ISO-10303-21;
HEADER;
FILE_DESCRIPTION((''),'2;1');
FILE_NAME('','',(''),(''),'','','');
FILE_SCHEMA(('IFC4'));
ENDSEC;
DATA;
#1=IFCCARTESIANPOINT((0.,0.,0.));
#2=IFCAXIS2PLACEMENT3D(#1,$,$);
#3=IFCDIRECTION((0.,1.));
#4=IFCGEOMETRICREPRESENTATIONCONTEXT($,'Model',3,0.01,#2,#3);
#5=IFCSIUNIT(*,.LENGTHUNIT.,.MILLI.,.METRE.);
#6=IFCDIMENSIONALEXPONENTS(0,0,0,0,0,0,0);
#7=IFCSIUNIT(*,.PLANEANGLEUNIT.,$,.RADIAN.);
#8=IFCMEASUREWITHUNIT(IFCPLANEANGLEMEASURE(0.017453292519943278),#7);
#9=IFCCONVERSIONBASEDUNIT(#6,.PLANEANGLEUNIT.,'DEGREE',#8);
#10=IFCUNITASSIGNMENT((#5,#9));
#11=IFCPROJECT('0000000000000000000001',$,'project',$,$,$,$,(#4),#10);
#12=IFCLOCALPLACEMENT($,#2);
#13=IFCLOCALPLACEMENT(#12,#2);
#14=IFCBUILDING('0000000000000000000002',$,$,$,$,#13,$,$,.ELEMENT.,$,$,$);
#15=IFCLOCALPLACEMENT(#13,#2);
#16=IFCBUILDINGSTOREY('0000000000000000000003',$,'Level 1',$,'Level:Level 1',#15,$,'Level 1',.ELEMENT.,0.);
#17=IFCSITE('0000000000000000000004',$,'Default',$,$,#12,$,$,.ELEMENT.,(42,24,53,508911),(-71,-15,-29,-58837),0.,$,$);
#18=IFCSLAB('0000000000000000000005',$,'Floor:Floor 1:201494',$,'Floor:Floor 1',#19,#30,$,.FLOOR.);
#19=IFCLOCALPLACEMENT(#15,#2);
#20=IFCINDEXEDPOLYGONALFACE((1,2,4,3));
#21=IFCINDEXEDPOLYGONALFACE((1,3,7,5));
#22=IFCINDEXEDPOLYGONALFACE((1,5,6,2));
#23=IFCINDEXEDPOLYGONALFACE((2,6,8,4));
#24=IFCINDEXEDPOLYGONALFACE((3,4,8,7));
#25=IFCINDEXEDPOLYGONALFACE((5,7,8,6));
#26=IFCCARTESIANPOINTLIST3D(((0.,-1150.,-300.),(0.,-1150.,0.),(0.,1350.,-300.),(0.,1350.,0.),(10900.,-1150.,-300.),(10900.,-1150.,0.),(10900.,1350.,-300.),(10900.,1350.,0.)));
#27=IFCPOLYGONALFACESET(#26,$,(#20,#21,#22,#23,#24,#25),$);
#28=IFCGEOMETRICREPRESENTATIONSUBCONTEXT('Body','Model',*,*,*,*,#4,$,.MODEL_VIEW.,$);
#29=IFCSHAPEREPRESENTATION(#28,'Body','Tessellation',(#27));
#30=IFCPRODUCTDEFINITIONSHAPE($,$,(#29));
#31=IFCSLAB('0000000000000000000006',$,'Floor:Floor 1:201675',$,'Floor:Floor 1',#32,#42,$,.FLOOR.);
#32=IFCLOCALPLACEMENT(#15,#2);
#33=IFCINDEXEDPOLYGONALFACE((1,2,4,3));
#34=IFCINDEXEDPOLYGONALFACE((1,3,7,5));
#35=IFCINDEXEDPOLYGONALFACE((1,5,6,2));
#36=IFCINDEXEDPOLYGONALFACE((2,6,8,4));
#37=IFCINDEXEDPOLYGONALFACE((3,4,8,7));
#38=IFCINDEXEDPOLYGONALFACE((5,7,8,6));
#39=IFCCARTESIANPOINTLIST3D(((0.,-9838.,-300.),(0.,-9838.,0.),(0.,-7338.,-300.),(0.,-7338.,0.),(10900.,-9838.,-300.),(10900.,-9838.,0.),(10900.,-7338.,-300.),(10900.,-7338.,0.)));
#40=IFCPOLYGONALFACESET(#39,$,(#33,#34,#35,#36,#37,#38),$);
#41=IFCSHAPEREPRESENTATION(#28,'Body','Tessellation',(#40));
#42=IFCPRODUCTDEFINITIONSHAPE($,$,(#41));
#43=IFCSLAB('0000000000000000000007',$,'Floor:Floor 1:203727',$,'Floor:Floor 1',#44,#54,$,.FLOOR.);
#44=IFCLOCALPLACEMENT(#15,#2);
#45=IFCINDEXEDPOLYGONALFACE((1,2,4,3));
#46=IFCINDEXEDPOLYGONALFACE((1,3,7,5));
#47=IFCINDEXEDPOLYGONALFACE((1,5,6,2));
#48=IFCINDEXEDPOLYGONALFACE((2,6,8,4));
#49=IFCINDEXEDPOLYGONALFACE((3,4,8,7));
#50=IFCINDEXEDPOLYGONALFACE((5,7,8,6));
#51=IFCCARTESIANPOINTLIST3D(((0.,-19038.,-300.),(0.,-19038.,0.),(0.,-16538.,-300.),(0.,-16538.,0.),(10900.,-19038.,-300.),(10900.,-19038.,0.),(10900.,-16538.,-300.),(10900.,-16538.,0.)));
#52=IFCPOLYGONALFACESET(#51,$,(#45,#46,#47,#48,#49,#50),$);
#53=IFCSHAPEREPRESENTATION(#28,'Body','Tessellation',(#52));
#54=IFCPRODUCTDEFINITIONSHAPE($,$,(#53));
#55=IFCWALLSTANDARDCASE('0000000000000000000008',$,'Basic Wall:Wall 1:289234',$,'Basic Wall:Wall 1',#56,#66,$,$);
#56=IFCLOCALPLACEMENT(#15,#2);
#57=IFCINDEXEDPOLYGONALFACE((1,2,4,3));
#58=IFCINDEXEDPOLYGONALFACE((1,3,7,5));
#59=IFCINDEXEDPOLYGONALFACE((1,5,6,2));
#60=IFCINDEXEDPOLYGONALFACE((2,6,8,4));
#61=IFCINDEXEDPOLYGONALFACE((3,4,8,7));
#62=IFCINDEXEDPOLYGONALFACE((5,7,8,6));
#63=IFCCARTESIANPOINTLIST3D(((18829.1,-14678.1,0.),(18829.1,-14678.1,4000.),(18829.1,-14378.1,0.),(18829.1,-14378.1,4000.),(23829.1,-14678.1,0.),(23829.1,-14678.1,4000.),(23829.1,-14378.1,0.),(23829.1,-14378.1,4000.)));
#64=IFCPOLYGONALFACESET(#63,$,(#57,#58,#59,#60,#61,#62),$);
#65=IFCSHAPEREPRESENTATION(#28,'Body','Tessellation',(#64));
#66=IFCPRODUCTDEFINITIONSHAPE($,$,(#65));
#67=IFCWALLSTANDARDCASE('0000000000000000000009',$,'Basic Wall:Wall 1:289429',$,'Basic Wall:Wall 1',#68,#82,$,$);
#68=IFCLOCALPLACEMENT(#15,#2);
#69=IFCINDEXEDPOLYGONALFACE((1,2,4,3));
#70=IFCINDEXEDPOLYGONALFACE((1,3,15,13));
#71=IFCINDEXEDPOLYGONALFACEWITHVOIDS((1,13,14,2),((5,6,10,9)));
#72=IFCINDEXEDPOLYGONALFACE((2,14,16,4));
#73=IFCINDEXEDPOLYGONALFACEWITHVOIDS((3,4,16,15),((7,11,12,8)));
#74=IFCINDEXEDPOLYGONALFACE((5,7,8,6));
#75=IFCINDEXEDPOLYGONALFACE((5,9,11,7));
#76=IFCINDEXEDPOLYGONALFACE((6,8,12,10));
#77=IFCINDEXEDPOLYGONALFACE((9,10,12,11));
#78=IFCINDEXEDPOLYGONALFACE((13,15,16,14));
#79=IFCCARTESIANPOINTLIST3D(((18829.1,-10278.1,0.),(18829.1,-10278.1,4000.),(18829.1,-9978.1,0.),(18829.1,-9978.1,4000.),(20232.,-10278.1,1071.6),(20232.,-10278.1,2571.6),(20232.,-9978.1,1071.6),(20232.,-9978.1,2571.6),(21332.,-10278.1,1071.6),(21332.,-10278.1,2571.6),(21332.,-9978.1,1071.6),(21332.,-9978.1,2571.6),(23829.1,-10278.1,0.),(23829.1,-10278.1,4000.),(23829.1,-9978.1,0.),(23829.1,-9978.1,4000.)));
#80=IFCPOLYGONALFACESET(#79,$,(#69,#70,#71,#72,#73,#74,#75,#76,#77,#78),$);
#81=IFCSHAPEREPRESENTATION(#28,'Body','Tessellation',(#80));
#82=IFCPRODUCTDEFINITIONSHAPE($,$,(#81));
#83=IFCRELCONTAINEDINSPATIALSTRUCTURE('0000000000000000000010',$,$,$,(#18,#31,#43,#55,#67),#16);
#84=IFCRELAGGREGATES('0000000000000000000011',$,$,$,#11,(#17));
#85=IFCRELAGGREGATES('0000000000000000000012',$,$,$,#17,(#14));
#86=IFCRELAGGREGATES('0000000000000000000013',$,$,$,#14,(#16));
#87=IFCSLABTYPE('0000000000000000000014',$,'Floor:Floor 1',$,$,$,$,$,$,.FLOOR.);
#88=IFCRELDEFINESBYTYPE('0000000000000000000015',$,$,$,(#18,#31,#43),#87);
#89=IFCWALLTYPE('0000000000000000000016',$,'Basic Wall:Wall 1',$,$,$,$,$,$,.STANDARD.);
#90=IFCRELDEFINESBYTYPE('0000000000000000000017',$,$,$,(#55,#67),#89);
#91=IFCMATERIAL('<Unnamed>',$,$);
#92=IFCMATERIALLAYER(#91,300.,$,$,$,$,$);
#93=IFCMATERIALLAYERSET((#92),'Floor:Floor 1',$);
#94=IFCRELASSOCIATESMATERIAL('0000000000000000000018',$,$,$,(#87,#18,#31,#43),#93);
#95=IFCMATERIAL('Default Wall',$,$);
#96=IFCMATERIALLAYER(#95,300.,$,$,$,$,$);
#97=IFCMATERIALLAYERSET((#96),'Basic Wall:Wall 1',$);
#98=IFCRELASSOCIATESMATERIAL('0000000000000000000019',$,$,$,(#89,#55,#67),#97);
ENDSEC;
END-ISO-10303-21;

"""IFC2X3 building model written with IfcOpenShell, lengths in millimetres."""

from ifc_helpers import new_model, entity, si_unit, converted_unit, direction, frame, frame_2d, origin, origin_2d_with_axis, place, context, subcontext, project, spatial, rectangle, extrude, material, layer, layer_set, layer_usage, type_object, element, save


model = new_model("IFC2X3")

# Units and contexts
model_context = context("Model", 3, precision=0.01, world=origin(), true_north=direction((0.0, 1.0)))
body_context = subcontext(model_context, "Body", "Model", "MODEL_VIEW")
ifc_project = project(units=[si_unit("LENGTHUNIT", "METRE", prefix="MILLI"), converted_unit("PLANEANGLEUNIT", "DEGREE", entity("IfcPlaneAngleMeasure", 0.017453292519943278), si_unit("PLANEANGLEUNIT", "RADIAN"), dimensions=[0, 0, 0, 0, 0, 0, 0])], contexts=[model_context])

# Site, building, storey
site_placement = place(None, origin())
site = spatial("IfcSite", under=ifc_project, at=site_placement, Name="Default", CompositionType="ELEMENT", RefLatitude=(42, 24, 53, 508911), RefLongitude=(-71, -15, -29, -58837), RefElevation=0.0)
building_placement = place(site_placement, origin())
building = spatial("IfcBuilding", under=site, at=building_placement, CompositionType="ELEMENT")
storey_placement = place(building_placement, origin())
storey = spatial("IfcBuildingStorey", under=building, at=storey_placement, Name="Level 1", ObjectType="Level:Level 1", LongName="Level 1", CompositionType="ELEMENT", Elevation=0.0)

# Slabs
ifc_material_1 = material(Name="<Unnamed>")
ifc_layer_1 = layer(ifc_material_1, 300.0)
ifc_layer_set_1 = layer_set([ifc_layer_1], Name="Floor:Floor 1")
ifc_layer_usage_1 = layer_usage(ifc_layer_set_1, "AXIS3", "POSITIVE", 0.0)
slab_type_1 = type_object("IfcSlabType", Name="Floor:Floor 1", PredefinedType="FLOOR", material=ifc_layer_set_1)
slab_1_placement = place(storey_placement, origin())
element("IfcSlab", 1, at=slab_1_placement, inside=storey, type_object=slab_type_1, material=ifc_layer_usage_1, Name="Floor:Floor 1:201494", ObjectType="Floor:Floor 1", PredefinedType="FLOOR", context=body_context, shape_type="SweptSolid", body=[
    extrude(rectangle(XDim=10900.0, YDim=2500.0, at=frame_2d((0.0, 0.0), x_axis=(1.0, 0.0))), frame((5450.0, 100.0, 0.0), z_axis=(0.0, 0.0, -1.0), x_axis=(1.0, 0.0, 0.0)), (0.0, 0.0, 1.0), 300.0),
])
ifc_layer_usage_2 = layer_usage(ifc_layer_set_1, "AXIS3", "POSITIVE", 0.0)
slab_2_placement = place(storey_placement, origin())
element("IfcSlab", 2, at=slab_2_placement, inside=storey, type_object=slab_type_1, material=ifc_layer_usage_2, Name="Floor:Floor 1:201675", ObjectType="Floor:Floor 1", PredefinedType="FLOOR", context=body_context, shape_type="SweptSolid", body=[
    extrude(rectangle(XDim=10900.0, YDim=2500.0, at=frame_2d((0.0, 0.0), x_axis=(1.0, 0.0))), frame((5450.0, -8588.0, 0.0), z_axis=(0.0, 0.0, -1.0), x_axis=(1.0, 0.0, 0.0)), (0.0, 0.0, 1.0), 300.0),
])
ifc_layer_usage_3 = layer_usage(ifc_layer_set_1, "AXIS3", "POSITIVE", 0.0)
slab_3_placement = place(storey_placement, origin())
element("IfcSlab", 3, at=slab_3_placement, inside=storey, type_object=slab_type_1, material=ifc_layer_usage_3, Name="Floor:Floor 1:203727", ObjectType="Floor:Floor 1", PredefinedType="FLOOR", context=body_context, shape_type="SweptSolid", body=[
    extrude(rectangle(XDim=10900.0, YDim=2500.0, at=frame_2d((0.0, 0.0), x_axis=(1.0, 0.0))), frame((5450.0, -17788.0, 0.0), z_axis=(0.0, 0.0, -1.0), x_axis=(1.0, 0.0, 0.0)), (0.0, 0.0, 1.0), 300.0),
])

# Wall
ifc_material_2 = material(Name="Default Wall")
ifc_layer_2 = layer(ifc_material_2, 300.0)
ifc_layer_set_2 = layer_set([ifc_layer_2], Name="Basic Wall:Wall 1")
ifc_layer_usage_4 = layer_usage(ifc_layer_set_2, "AXIS2", "NEGATIVE", 150.0)
wall_type = type_object("IfcWallType", Name="Basic Wall:Wall 1", PredefinedType="STANDARD", material=ifc_layer_set_2)
wall_1_placement = place(storey_placement, frame((18829.1, -14528.1, 0.0)))
element("IfcWallStandardCase", 4, at=wall_1_placement, inside=storey, type_object=wall_type, material=ifc_layer_usage_4, Name="Basic Wall:Wall 1:289234", ObjectType="Basic Wall:Wall 1", context=body_context, shape_type="SweptSolid", body=[
    extrude(rectangle(XDim=5000.0, YDim=300.0, at=frame_2d((2500.0, 0.0), x_axis=(-1.0, 0.0))), origin(), (0.0, 0.0, 1.0), 4000.0),
])

# Wall, opening
ifc_layer_usage_5 = layer_usage(ifc_layer_set_2, "AXIS2", "NEGATIVE", 150.0)
wall_2_placement = place(storey_placement, frame((18829.1, -10128.1, 0.0)))
wall_2 = element("IfcWallStandardCase", 5, at=wall_2_placement, inside=storey, type_object=wall_type, material=ifc_layer_usage_5, Name="Basic Wall:Wall 1:289429", ObjectType="Basic Wall:Wall 1", context=body_context, shape_type="SweptSolid", body=[
    extrude(rectangle(XDim=5000.0, YDim=300.0, at=frame_2d((2500.0, 0.0), x_axis=(-1.0, 0.0))), origin(), (0.0, 0.0, 1.0), 4000.0),
])
opening_placement = place(wall_2_placement, origin())
element("IfcOpeningElement", 6, at=opening_placement, cuts=wall_2, ObjectType="Opening", context=body_context, shape_type="SweptSolid", body=[
    extrude(rectangle(XDim=1500.0, YDim=1100.0, at=origin_2d_with_axis()), frame((1952.9, -459.7, 1821.6), z_axis=(0.0, 1.0, 0.0), x_axis=(0.0, 0.0, -1.0)), (0.0, 0.0, 1.0), 1069.7),
])

save(model, "model.ifc")
